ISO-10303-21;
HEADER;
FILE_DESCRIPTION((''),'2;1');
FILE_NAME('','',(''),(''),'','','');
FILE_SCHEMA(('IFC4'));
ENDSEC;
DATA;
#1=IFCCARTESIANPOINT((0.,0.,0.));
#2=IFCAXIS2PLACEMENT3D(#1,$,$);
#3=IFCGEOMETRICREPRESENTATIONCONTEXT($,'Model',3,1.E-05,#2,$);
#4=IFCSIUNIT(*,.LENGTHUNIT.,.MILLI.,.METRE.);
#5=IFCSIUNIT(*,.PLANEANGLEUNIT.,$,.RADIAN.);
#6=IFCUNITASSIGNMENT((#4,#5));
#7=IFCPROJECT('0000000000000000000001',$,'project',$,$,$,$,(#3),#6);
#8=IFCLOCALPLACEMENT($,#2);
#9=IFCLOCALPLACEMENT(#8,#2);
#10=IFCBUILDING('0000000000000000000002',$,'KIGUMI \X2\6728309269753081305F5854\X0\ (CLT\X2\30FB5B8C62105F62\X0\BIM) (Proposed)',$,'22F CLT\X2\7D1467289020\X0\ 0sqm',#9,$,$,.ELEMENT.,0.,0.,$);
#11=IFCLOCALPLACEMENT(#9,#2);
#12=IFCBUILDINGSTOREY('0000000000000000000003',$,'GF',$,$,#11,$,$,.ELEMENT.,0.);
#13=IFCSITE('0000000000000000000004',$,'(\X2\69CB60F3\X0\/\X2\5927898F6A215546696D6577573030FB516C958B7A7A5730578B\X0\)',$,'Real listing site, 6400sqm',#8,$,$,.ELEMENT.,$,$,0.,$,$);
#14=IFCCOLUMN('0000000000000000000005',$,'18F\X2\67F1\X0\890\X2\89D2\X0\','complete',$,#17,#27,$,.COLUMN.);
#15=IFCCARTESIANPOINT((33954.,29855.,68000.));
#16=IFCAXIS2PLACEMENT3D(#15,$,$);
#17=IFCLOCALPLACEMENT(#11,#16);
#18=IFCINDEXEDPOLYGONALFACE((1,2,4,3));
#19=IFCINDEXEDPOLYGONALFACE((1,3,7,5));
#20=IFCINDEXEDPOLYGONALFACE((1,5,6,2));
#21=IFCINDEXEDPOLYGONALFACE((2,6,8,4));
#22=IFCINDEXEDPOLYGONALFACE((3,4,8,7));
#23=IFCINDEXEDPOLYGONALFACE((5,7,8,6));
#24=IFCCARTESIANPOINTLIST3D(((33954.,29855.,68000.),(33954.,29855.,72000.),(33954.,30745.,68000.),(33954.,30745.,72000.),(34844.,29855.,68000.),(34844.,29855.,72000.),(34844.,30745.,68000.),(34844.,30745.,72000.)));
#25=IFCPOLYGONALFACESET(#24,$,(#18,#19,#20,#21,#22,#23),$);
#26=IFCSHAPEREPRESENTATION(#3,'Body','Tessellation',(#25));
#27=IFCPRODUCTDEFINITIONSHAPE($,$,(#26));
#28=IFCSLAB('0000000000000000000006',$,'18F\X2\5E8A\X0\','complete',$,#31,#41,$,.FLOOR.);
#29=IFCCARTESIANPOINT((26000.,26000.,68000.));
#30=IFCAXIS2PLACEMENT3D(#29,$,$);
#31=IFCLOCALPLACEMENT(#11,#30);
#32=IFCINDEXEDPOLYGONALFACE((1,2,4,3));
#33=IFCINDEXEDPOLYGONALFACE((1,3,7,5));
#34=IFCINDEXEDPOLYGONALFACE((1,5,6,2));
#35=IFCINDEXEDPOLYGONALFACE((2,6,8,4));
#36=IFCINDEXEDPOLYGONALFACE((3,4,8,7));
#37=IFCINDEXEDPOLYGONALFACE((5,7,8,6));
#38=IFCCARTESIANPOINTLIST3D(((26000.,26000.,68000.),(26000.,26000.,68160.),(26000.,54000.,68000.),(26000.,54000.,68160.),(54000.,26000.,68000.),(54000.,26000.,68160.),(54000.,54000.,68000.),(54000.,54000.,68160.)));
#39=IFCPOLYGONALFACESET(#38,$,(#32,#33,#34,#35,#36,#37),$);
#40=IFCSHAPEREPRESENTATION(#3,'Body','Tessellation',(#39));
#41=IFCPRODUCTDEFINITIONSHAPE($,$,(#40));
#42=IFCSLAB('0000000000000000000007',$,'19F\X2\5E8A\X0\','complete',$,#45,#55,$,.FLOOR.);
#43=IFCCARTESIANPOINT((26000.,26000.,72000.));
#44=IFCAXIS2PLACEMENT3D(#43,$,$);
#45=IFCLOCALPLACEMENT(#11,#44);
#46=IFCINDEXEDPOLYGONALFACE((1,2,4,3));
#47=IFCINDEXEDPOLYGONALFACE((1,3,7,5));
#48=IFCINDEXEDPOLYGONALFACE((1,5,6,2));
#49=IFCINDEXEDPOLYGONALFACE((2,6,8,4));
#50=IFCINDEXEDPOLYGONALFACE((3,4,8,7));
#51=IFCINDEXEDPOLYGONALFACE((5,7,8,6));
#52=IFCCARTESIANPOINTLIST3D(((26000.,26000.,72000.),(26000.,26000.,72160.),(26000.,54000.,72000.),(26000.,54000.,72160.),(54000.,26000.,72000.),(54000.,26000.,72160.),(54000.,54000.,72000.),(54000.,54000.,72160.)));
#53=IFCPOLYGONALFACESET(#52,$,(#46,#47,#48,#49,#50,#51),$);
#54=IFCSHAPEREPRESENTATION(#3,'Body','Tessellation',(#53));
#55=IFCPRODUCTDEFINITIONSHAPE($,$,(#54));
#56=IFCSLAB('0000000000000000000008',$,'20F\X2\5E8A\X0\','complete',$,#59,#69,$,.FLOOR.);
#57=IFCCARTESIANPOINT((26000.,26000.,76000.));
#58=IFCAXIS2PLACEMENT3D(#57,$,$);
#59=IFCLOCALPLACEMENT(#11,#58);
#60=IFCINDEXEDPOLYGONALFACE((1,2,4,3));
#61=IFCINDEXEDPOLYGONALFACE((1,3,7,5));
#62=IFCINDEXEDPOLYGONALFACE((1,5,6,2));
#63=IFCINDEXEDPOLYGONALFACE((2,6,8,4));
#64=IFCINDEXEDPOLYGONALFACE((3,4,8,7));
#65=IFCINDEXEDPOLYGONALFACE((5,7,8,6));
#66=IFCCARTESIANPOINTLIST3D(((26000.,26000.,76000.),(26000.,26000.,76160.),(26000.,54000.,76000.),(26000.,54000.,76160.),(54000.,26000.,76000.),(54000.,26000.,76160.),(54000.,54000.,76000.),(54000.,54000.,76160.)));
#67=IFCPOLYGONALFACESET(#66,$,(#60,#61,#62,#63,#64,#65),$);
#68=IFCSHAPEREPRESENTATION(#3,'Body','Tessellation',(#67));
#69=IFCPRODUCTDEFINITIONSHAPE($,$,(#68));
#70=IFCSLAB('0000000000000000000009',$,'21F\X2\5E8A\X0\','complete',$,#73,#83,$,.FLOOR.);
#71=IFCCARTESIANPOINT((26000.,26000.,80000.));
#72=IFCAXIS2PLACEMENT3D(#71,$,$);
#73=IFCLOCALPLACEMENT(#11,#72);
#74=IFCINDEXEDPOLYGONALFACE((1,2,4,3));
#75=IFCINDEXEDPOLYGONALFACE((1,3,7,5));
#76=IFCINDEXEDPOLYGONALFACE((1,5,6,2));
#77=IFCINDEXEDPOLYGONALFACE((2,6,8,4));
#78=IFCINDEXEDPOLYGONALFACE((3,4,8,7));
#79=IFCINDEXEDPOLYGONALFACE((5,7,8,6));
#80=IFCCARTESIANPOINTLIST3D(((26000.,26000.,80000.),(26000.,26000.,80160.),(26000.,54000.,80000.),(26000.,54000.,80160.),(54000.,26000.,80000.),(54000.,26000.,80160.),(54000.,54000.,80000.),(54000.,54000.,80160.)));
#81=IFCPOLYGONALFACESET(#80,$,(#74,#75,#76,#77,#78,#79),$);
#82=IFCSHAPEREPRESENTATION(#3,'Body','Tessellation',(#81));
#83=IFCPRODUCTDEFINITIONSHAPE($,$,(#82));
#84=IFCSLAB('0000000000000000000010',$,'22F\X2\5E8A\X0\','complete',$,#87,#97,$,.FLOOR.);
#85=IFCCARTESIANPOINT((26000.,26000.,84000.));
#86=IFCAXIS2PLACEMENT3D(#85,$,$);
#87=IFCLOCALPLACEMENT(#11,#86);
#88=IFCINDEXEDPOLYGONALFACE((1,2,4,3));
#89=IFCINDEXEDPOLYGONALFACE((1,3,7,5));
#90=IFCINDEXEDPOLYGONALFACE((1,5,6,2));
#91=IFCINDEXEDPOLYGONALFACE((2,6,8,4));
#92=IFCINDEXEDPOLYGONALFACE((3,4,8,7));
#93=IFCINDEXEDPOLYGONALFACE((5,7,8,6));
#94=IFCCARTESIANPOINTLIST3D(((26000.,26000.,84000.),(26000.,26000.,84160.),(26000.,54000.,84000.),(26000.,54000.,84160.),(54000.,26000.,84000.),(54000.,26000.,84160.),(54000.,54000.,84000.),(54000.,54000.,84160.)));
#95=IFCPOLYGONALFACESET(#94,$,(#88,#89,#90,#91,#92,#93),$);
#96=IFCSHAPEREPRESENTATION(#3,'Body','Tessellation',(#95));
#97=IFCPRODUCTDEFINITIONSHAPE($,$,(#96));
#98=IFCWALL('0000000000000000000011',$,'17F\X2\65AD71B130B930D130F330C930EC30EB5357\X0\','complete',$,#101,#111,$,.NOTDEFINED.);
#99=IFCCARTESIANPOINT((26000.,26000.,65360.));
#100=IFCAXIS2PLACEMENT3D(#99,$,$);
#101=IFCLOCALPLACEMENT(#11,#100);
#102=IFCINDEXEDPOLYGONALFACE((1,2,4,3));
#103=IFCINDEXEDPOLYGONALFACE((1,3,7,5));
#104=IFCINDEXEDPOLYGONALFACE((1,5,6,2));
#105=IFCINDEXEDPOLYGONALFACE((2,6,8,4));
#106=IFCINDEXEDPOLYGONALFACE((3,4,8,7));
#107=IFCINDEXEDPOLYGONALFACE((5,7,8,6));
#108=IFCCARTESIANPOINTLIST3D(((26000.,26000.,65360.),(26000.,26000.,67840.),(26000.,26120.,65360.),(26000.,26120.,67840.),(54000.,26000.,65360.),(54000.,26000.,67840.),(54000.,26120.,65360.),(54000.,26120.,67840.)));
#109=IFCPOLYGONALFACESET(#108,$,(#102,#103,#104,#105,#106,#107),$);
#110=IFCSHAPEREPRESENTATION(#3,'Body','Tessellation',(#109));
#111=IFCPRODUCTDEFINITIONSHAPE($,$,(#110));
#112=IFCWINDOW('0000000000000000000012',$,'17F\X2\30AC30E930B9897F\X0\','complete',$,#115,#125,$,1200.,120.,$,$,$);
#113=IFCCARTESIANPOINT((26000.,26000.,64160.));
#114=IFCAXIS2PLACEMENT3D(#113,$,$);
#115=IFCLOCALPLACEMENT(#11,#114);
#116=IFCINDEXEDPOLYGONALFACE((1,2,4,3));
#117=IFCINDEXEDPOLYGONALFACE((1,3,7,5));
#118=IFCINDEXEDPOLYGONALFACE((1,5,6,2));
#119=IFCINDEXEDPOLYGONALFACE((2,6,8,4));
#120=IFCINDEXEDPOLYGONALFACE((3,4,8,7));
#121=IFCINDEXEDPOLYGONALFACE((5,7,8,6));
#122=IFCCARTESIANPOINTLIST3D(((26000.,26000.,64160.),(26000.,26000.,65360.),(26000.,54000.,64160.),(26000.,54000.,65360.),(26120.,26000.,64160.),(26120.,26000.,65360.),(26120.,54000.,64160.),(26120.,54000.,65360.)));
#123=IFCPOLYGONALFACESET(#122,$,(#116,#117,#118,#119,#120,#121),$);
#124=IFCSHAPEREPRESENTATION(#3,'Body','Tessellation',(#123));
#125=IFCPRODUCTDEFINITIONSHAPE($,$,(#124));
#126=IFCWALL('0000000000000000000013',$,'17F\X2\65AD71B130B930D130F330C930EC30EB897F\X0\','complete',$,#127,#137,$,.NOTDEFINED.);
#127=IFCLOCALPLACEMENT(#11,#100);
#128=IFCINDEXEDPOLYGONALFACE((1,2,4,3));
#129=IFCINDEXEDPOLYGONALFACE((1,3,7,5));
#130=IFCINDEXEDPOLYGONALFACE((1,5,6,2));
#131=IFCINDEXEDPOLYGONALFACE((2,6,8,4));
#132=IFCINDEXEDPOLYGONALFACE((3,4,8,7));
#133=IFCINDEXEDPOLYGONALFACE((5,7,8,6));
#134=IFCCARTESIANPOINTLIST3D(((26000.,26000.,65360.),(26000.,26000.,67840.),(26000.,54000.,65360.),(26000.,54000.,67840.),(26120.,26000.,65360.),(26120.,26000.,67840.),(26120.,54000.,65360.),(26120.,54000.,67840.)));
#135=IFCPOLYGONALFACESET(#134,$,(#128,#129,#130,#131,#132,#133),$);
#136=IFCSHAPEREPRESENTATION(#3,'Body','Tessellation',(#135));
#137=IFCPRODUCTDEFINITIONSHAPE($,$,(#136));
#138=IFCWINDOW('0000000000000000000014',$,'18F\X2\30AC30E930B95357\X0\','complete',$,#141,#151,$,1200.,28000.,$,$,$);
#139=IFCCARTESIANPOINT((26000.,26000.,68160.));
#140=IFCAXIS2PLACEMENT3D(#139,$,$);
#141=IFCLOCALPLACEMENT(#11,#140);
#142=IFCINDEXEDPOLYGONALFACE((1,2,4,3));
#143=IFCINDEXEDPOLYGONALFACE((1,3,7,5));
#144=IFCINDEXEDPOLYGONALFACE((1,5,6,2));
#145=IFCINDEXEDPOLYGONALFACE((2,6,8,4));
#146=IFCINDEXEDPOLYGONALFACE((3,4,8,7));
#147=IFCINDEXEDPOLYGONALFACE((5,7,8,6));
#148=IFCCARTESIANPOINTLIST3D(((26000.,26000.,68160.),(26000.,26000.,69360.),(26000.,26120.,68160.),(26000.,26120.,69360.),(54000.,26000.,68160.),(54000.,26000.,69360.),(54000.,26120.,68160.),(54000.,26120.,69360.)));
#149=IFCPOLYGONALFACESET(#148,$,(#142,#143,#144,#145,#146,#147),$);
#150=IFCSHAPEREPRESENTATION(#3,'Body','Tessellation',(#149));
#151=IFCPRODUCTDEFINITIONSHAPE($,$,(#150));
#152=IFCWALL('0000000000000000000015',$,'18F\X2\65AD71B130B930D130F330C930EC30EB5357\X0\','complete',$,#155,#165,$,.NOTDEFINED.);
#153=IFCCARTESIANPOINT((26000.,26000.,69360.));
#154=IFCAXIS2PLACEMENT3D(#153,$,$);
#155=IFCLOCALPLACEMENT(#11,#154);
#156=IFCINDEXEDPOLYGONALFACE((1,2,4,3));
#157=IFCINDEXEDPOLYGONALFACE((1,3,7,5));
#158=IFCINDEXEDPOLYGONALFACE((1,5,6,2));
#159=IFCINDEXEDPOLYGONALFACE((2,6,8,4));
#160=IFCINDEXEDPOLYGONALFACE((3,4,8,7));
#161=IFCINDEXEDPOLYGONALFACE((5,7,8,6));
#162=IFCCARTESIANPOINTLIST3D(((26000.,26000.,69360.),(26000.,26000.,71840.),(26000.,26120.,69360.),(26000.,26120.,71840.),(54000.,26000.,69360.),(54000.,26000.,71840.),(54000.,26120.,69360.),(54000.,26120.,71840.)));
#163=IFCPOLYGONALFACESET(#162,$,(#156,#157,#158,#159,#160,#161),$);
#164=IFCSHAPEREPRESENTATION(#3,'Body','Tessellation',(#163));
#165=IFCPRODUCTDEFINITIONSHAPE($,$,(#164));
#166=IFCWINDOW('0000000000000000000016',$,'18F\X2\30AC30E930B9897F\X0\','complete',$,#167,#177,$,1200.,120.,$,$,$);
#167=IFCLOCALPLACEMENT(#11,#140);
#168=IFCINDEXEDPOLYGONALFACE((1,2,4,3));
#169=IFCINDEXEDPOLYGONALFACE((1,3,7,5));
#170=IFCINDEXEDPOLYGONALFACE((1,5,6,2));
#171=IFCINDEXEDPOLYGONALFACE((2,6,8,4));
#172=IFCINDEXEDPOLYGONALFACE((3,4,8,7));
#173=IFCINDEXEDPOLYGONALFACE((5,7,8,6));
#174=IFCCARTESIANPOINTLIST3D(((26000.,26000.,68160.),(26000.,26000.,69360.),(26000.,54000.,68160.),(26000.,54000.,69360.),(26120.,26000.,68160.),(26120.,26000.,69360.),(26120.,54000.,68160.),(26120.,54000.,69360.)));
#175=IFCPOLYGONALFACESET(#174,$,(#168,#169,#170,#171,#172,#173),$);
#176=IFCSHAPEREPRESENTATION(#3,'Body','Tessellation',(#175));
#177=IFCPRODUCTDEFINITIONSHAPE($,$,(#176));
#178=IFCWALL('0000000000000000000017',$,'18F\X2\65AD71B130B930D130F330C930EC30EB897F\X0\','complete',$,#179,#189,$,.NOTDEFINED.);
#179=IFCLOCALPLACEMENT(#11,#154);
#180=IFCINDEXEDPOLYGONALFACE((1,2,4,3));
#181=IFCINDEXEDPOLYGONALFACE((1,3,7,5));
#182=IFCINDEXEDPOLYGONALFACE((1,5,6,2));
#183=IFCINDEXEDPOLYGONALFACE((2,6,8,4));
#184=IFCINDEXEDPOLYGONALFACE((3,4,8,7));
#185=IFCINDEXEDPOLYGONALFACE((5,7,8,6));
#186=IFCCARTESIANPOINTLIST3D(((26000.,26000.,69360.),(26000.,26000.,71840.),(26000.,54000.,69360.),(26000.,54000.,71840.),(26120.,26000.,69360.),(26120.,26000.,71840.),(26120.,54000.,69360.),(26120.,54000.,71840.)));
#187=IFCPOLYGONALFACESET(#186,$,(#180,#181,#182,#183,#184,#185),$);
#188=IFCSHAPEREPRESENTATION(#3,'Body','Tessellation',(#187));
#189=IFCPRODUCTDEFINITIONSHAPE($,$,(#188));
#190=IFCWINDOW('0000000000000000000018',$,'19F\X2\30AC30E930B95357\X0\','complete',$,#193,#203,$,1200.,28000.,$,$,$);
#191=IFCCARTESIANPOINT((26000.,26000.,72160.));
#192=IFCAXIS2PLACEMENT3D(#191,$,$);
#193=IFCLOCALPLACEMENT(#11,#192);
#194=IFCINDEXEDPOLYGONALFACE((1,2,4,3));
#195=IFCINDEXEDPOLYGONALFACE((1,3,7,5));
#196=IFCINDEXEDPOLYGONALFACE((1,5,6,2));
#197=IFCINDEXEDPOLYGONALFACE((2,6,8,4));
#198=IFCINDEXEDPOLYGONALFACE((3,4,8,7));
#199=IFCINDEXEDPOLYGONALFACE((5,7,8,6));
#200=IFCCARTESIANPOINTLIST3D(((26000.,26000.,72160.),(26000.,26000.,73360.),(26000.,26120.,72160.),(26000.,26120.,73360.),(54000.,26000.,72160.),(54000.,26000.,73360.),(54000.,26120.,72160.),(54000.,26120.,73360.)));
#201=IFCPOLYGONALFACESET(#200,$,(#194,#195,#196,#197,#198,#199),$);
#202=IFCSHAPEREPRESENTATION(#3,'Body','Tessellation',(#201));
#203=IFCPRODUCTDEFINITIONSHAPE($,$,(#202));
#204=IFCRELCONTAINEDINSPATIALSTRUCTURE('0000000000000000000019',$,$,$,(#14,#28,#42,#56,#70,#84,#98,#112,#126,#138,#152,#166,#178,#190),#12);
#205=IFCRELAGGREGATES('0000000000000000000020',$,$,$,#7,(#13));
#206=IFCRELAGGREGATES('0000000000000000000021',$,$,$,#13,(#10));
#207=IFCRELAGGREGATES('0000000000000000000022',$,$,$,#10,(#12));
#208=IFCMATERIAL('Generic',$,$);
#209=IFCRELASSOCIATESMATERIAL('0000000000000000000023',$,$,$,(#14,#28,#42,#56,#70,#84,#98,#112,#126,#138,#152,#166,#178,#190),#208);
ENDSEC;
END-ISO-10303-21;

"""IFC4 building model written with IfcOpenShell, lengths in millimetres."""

from ifc_helpers import new_model, si_unit, frame, frame_2d, origin, place, context, project, spatial, rectangle, extrude, material, element, save


model = new_model("IFC4")

# Units and contexts
model_context = context("Model", 3, precision=1e-05, world=origin())
ifc_project = project(units=[si_unit("LENGTHUNIT", "METRE", prefix="MILLI"), si_unit("PLANEANGLEUNIT", "RADIAN")], contexts=[model_context])

# Site, building, storey
site_placement = place(None, origin())
site = spatial("IfcSite", under=ifc_project, at=site_placement, Name="(構想/大規模商業敷地・公開空地型)", ObjectType="Real listing site, 6400sqm", CompositionType="ELEMENT", RefElevation=0.0)
building_placement = place(site_placement, origin())
building = spatial("IfcBuilding", under=site, at=building_placement, Name="KIGUMI 木を極めた塔 (CLT・完成形BIM) (Proposed)", ObjectType="22F CLT純木造 0sqm", CompositionType="ELEMENT", ElevationOfRefHeight=0.0, ElevationOfTerrain=0.0)
storey_placement = place(building_placement, origin())
storey = spatial("IfcBuildingStorey", under=building, at=storey_placement, Name="GF", CompositionType="ELEMENT", Elevation=0.0)

# Column
ifc_material = material(Name="Generic")
column_placement = place(storey_placement, frame((33954.0, 29855.0, 68000.0)))
element("IfcColumn", 1, at=column_placement, inside=storey, material=ifc_material, Name="18F柱890角", Description="complete", PredefinedType="COLUMN", context=model_context, shape_type="SweptSolid", body=[
    extrude(rectangle(XDim=890.0, YDim=890.0, at=frame_2d((445.0, 445.0))), frame((33954.0, 29855.0, 68000.0)), (0.0, 0.0, 1.0), 4000.0),
])

# Slabs
slab_1_placement = place(storey_placement, frame((26000.0, 26000.0, 68000.0)))
element("IfcSlab", 2, at=slab_1_placement, inside=storey, material=ifc_material, Name="18F床", Description="complete", PredefinedType="FLOOR", context=model_context, shape_type="SweptSolid", body=[
    extrude(rectangle(XDim=28000.0, YDim=28000.0, at=frame_2d((14000.0, 14000.0))), frame((26000.0, 26000.0, 68000.0)), (0.0, 0.0, 1.0), 160.0),
])
slab_2_placement = place(storey_placement, frame((26000.0, 26000.0, 72000.0)))
element("IfcSlab", 3, at=slab_2_placement, inside=storey, material=ifc_material, Name="19F床", Description="complete", PredefinedType="FLOOR", context=model_context, shape_type="SweptSolid", body=[
    extrude(rectangle(XDim=28000.0, YDim=28000.0, at=frame_2d((14000.0, 14000.0))), frame((26000.0, 26000.0, 72000.0)), (0.0, 0.0, 1.0), 160.0),
])
slab_3_placement = place(storey_placement, frame((26000.0, 26000.0, 76000.0)))
element("IfcSlab", 4, at=slab_3_placement, inside=storey, material=ifc_material, Name="20F床", Description="complete", PredefinedType="FLOOR", context=model_context, shape_type="SweptSolid", body=[
    extrude(rectangle(XDim=28000.0, YDim=28000.0, at=frame_2d((14000.0, 14000.0))), frame((26000.0, 26000.0, 76000.0)), (0.0, 0.0, 1.0), 160.0),
])
slab_4_placement = place(storey_placement, frame((26000.0, 26000.0, 80000.0)))
element("IfcSlab", 5, at=slab_4_placement, inside=storey, material=ifc_material, Name="21F床", Description="complete", PredefinedType="FLOOR", context=model_context, shape_type="SweptSolid", body=[
    extrude(rectangle(XDim=28000.0, YDim=28000.0, at=frame_2d((14000.0, 14000.0))), frame((26000.0, 26000.0, 80000.0)), (0.0, 0.0, 1.0), 160.0),
])
slab_5_placement = place(storey_placement, frame((26000.0, 26000.0, 84000.0)))
element("IfcSlab", 6, at=slab_5_placement, inside=storey, material=ifc_material, Name="22F床", Description="complete", PredefinedType="FLOOR", context=model_context, shape_type="SweptSolid", body=[
    extrude(rectangle(XDim=28000.0, YDim=28000.0, at=frame_2d((14000.0, 14000.0))), frame((26000.0, 26000.0, 84000.0)), (0.0, 0.0, 1.0), 160.0),
])

# Wall
wall_1_placement = place(storey_placement, frame((26000.0, 26000.0, 65360.0)))
element("IfcWall", 7, at=wall_1_placement, inside=storey, material=ifc_material, Name="17F断熱スパンドレル南", Description="complete", PredefinedType="NOTDEFINED", context=model_context, shape_type="SweptSolid", body=[
    extrude(rectangle(XDim=28000.0, YDim=120.0, at=frame_2d((14000.0, 60.0))), frame((26000.0, 26000.0, 65360.0)), (0.0, 0.0, 1.0), 2480.0),
])

# Window
window_1_placement = place(storey_placement, frame((26000.0, 26000.0, 64160.0)))
element("IfcWindow", 8, at=window_1_placement, inside=storey, material=ifc_material, Name="17Fガラス西", Description="complete", OverallHeight=1200.0, OverallWidth=120.0, context=model_context, shape_type="SweptSolid", body=[
    extrude(rectangle(XDim=120.0, YDim=28000.0, at=frame_2d((60.0, 14000.0))), frame((26000.0, 26000.0, 64160.0)), (0.0, 0.0, 1.0), 1200.0),
])

# Wall
wall_2_placement = place(storey_placement, frame((26000.0, 26000.0, 65360.0)))
element("IfcWall", 9, at=wall_2_placement, inside=storey, material=ifc_material, Name="17F断熱スパンドレル西", Description="complete", PredefinedType="NOTDEFINED", context=model_context, shape_type="SweptSolid", body=[
    extrude(rectangle(XDim=120.0, YDim=28000.0, at=frame_2d((60.0, 14000.0))), frame((26000.0, 26000.0, 65360.0)), (0.0, 0.0, 1.0), 2480.0),
])

# Window
window_2_placement = place(storey_placement, frame((26000.0, 26000.0, 68160.0)))
element("IfcWindow", 10, at=window_2_placement, inside=storey, material=ifc_material, Name="18Fガラス南", Description="complete", OverallHeight=1200.0, OverallWidth=28000.0, context=model_context, shape_type="SweptSolid", body=[
    extrude(rectangle(XDim=28000.0, YDim=120.0, at=frame_2d((14000.0, 60.0))), frame((26000.0, 26000.0, 68160.0)), (0.0, 0.0, 1.0), 1200.0),
])

# Wall
wall_3_placement = place(storey_placement, frame((26000.0, 26000.0, 69360.0)))
element("IfcWall", 11, at=wall_3_placement, inside=storey, material=ifc_material, Name="18F断熱スパンドレル南", Description="complete", PredefinedType="NOTDEFINED", context=model_context, shape_type="SweptSolid", body=[
    extrude(rectangle(XDim=28000.0, YDim=120.0, at=frame_2d((14000.0, 60.0))), frame((26000.0, 26000.0, 69360.0)), (0.0, 0.0, 1.0), 2480.0),
])

# Window
window_3_placement = place(storey_placement, frame((26000.0, 26000.0, 68160.0)))
element("IfcWindow", 12, at=window_3_placement, inside=storey, material=ifc_material, Name="18Fガラス西", Description="complete", OverallHeight=1200.0, OverallWidth=120.0, context=model_context, shape_type="SweptSolid", body=[
    extrude(rectangle(XDim=120.0, YDim=28000.0, at=frame_2d((60.0, 14000.0))), frame((26000.0, 26000.0, 68160.0)), (0.0, 0.0, 1.0), 1200.0),
])

# Wall
wall_4_placement = place(storey_placement, frame((26000.0, 26000.0, 69360.0)))
element("IfcWall", 13, at=wall_4_placement, inside=storey, material=ifc_material, Name="18F断熱スパンドレル西", Description="complete", PredefinedType="NOTDEFINED", context=model_context, shape_type="SweptSolid", body=[
    extrude(rectangle(XDim=120.0, YDim=28000.0, at=frame_2d((60.0, 14000.0))), frame((26000.0, 26000.0, 69360.0)), (0.0, 0.0, 1.0), 2480.0),
])

# Window
window_4_placement = place(storey_placement, frame((26000.0, 26000.0, 72160.0)))
element("IfcWindow", 14, at=window_4_placement, inside=storey, material=ifc_material, Name="19Fガラス南", Description="complete", OverallHeight=1200.0, OverallWidth=28000.0, context=model_context, shape_type="SweptSolid", body=[
    extrude(rectangle(XDim=28000.0, YDim=120.0, at=frame_2d((14000.0, 60.0))), frame((26000.0, 26000.0, 72160.0)), (0.0, 0.0, 1.0), 1200.0),
])

save(model, "model.ifc")
